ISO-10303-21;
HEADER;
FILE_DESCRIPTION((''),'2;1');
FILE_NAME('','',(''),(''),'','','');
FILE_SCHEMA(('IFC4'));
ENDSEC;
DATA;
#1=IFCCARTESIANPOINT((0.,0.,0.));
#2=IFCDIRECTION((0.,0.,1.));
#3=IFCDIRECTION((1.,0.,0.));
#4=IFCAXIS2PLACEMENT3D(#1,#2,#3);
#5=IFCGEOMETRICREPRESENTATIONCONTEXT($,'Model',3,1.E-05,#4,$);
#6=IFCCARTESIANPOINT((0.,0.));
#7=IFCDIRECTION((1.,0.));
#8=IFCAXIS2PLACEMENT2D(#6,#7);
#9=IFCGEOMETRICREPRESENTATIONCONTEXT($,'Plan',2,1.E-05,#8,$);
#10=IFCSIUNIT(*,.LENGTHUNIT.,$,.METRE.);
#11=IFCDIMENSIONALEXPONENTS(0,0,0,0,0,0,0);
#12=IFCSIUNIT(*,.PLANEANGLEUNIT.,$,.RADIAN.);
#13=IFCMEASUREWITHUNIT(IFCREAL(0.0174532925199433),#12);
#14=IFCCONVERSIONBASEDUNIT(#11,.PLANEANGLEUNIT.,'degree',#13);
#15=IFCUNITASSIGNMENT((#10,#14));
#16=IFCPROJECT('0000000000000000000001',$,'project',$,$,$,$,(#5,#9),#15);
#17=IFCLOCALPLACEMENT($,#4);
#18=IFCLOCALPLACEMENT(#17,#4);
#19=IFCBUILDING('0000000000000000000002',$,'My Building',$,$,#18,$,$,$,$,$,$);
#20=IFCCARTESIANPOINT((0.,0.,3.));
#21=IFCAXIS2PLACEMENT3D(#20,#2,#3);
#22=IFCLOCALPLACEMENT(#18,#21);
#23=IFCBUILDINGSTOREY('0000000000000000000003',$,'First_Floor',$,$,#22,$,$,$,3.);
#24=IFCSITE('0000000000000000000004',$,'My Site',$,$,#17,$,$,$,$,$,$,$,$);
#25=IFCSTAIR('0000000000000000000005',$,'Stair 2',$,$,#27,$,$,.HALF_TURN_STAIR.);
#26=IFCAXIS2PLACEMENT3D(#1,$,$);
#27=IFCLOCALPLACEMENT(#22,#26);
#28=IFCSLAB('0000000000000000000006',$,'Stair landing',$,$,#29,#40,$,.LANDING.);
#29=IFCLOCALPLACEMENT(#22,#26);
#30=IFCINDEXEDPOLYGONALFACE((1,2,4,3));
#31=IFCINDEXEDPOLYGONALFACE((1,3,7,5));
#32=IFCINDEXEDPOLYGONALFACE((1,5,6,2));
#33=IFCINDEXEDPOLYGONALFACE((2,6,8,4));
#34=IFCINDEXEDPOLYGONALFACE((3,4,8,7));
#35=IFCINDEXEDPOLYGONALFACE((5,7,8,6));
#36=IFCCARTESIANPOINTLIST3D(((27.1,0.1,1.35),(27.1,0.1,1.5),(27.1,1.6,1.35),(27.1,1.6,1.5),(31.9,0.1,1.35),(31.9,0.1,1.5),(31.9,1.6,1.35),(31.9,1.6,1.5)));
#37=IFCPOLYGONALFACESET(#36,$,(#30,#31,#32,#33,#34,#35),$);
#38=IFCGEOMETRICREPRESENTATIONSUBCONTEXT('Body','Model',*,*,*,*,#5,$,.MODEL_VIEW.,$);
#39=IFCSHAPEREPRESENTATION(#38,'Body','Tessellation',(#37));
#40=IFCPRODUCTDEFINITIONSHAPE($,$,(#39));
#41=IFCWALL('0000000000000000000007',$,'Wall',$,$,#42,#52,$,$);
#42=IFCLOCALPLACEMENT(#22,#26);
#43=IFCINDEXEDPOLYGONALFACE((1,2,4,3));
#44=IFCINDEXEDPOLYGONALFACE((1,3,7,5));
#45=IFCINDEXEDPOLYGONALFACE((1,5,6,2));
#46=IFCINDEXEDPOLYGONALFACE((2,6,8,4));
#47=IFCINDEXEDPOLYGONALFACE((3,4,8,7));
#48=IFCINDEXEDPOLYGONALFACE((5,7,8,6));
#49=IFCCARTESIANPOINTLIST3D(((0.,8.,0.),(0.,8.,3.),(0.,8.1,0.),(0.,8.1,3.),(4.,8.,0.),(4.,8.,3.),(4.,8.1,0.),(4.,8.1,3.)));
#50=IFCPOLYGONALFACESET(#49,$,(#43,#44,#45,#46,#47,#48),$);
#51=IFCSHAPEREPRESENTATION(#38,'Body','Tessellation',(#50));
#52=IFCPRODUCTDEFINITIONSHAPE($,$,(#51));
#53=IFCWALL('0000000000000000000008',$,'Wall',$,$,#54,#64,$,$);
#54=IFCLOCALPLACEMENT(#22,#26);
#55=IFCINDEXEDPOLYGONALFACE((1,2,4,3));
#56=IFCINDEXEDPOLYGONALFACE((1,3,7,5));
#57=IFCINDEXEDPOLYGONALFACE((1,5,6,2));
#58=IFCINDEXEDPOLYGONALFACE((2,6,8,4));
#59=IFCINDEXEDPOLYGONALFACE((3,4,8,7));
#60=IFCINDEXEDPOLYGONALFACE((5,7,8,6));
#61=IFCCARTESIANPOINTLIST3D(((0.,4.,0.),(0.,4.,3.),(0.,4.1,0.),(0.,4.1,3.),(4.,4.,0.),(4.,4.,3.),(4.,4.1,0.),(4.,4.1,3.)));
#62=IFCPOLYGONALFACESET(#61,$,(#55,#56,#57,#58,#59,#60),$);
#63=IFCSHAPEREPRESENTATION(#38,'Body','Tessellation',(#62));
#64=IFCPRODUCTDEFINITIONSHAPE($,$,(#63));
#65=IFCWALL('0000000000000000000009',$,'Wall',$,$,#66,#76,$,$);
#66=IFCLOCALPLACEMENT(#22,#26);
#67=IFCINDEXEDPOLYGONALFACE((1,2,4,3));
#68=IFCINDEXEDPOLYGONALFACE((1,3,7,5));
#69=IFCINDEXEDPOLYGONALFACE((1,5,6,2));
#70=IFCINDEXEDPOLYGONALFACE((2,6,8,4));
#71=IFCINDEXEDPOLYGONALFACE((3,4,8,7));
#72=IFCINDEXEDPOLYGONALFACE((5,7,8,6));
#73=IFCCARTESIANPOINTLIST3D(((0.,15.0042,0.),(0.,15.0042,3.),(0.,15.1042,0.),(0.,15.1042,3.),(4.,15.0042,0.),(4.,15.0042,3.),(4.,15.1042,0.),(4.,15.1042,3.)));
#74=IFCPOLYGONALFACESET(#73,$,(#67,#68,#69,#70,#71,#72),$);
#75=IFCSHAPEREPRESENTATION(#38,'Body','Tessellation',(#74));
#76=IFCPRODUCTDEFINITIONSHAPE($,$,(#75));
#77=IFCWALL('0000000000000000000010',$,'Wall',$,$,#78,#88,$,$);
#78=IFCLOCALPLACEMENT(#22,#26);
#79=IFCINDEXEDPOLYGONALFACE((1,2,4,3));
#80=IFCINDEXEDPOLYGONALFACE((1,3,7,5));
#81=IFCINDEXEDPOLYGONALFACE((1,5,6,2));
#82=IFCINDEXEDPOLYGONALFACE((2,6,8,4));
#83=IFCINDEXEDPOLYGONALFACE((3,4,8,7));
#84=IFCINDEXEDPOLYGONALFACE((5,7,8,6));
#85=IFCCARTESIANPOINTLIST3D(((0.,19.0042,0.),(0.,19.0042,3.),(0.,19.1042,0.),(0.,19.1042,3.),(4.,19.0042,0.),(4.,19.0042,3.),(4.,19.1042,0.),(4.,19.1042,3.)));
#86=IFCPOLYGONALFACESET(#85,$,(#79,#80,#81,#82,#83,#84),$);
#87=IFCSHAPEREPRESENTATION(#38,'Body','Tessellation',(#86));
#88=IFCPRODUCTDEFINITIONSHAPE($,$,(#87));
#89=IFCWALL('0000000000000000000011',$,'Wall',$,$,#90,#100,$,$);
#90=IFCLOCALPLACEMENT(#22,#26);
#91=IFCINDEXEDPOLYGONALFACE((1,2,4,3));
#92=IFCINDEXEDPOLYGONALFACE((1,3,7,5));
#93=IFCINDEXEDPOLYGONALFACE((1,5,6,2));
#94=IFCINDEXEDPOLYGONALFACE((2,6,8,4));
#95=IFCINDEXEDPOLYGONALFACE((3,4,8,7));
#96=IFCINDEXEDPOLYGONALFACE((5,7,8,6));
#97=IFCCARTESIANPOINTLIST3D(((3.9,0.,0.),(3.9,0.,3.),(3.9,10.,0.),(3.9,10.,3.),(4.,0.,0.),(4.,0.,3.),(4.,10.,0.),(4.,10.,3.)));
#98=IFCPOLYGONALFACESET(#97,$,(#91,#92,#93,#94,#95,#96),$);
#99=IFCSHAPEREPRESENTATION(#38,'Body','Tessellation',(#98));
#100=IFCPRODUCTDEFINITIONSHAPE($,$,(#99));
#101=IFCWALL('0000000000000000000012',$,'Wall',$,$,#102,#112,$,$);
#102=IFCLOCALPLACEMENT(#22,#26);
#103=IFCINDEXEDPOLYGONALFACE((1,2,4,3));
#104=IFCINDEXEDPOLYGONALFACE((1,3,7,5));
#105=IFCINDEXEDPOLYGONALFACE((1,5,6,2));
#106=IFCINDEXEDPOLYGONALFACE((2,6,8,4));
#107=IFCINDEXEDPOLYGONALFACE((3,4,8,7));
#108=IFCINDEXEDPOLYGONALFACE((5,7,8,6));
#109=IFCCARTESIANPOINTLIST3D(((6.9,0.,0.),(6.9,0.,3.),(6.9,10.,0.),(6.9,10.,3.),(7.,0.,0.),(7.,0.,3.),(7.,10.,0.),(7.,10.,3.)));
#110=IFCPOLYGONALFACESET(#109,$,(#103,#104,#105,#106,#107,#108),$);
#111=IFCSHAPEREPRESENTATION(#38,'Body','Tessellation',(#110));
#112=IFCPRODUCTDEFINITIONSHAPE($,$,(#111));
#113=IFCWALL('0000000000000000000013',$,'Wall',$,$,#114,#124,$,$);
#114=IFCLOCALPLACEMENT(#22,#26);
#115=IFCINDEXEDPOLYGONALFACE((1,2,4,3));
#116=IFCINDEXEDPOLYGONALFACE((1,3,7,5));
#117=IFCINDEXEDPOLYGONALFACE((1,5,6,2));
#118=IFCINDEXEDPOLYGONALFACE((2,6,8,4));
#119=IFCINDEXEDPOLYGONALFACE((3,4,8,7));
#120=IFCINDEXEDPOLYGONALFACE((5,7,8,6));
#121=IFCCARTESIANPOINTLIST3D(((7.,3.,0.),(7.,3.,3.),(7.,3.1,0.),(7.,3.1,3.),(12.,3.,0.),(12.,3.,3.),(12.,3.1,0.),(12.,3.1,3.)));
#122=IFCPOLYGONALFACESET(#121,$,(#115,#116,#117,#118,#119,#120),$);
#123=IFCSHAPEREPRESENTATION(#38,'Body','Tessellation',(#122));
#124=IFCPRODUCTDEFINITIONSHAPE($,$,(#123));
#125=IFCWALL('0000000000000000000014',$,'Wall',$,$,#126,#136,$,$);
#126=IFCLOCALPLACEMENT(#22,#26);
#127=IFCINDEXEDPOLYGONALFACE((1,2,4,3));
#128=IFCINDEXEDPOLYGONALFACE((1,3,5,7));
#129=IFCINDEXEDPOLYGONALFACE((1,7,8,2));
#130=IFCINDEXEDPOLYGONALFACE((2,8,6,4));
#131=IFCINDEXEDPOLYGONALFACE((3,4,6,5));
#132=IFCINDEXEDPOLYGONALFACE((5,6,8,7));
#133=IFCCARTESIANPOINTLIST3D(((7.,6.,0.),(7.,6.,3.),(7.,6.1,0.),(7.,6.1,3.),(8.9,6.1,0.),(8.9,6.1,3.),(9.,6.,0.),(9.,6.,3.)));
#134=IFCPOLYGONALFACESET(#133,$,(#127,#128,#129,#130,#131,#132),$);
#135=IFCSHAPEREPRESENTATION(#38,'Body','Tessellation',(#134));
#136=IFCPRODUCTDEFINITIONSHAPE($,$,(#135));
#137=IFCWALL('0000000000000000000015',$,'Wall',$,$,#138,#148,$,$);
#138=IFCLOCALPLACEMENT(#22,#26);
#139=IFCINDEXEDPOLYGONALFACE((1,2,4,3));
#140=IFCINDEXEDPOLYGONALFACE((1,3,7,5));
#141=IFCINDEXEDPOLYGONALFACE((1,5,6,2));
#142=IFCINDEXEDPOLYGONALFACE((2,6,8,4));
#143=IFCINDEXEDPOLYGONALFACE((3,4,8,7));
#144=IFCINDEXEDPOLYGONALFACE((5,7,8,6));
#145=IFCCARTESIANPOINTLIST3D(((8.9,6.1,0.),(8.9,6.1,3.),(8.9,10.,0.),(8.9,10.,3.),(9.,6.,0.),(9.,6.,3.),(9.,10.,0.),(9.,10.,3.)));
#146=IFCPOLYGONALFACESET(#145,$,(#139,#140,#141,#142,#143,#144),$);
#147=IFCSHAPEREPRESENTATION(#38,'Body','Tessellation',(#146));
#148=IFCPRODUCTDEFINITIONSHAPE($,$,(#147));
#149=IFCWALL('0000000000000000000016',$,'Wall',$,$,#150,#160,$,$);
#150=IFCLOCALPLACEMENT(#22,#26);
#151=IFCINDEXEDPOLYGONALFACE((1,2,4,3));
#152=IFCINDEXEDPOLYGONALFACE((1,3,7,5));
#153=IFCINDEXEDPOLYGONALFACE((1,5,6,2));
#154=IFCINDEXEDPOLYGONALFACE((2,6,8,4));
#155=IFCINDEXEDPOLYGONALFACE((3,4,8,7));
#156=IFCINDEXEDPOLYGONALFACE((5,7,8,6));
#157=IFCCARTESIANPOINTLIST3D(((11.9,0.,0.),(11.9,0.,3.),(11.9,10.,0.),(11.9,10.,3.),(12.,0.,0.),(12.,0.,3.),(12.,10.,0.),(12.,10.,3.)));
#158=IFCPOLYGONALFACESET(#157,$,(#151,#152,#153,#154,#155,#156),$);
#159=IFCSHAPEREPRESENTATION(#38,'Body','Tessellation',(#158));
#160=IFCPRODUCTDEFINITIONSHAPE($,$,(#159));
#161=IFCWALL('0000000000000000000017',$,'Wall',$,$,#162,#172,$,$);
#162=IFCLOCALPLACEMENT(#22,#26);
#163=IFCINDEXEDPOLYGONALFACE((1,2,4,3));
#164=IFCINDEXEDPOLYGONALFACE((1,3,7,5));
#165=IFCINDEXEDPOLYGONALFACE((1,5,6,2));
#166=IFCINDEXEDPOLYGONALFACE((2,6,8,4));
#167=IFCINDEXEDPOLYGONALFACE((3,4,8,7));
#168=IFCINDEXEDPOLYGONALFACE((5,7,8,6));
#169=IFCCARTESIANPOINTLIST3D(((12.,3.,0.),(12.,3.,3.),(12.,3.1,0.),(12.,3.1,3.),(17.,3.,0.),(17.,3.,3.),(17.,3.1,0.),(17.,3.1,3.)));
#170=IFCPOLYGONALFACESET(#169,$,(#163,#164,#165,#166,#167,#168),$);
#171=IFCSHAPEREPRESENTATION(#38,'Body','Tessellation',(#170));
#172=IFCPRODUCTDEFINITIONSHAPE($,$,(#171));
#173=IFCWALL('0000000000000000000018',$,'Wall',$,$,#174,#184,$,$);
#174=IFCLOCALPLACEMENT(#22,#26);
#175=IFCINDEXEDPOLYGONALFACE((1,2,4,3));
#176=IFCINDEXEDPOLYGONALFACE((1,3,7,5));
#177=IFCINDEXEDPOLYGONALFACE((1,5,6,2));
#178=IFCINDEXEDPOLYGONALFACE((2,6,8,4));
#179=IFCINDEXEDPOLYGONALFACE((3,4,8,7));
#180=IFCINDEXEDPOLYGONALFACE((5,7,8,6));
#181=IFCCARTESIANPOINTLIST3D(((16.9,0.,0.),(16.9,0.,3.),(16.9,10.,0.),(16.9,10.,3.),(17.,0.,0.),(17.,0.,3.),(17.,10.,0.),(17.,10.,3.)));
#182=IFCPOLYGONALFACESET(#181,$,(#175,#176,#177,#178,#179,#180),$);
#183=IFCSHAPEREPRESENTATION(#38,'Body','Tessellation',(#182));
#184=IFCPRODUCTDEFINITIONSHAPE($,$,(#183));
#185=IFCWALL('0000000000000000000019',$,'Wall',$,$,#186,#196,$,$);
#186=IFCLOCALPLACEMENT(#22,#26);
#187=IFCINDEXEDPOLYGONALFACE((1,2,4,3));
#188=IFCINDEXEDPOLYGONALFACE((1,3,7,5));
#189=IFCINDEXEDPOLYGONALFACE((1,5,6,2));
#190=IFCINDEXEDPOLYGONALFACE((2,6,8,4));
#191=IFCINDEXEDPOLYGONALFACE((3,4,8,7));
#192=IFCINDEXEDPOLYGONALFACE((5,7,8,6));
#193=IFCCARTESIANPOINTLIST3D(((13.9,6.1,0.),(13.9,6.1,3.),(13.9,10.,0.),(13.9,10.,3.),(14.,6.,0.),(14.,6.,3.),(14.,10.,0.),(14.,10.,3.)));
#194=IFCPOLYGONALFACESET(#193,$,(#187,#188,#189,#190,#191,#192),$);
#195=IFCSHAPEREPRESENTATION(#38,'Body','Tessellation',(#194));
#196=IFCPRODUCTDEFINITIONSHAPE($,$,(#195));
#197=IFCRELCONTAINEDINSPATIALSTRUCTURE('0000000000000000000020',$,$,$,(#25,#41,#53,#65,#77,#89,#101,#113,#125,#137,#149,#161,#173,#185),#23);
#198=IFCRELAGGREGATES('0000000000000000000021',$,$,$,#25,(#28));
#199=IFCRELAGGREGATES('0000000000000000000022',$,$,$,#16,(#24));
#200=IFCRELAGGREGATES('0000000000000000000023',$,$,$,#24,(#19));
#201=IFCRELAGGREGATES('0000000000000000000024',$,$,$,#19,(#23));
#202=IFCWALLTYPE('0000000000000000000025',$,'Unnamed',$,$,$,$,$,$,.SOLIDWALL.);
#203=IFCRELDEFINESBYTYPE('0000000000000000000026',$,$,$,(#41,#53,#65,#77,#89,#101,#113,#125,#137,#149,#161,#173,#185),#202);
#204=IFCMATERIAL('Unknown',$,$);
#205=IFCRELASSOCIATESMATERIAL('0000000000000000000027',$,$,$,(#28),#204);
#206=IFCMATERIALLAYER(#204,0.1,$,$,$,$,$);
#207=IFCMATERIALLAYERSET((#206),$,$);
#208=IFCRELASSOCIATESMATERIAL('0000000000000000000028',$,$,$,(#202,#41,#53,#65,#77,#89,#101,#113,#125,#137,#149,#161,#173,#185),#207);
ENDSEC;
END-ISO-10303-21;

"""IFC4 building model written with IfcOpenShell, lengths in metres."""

from ifc_helpers import new_model, entity, si_unit, converted_unit, frame, frame_2d, origin_with_axes, origin_2d_with_axis, place, context, subcontext, project, spatial, line, indexed_curve, rectangle, outline, extrude, material, layer, layer_set, layer_usage, type_object, element, aggregate, save


model = new_model("IFC4")

# Units and contexts
model_context = context("Model", 3, precision=1e-05, world=origin_with_axes())
plan_context = context("Plan", 2, precision=1e-05, world=origin_2d_with_axis())
body_context = subcontext(model_context, "Body", "Model", "MODEL_VIEW")
ifc_project = project(units=[si_unit("LENGTHUNIT", "METRE"), converted_unit("PLANEANGLEUNIT", "degree", entity("IfcReal", 0.0174532925199433), si_unit("PLANEANGLEUNIT", "RADIAN"), dimensions=[0, 0, 0, 0, 0, 0, 0])], contexts=[model_context, plan_context])

# Site, building, storey
site_placement = place(None, origin_with_axes())
site = spatial("IfcSite", under=ifc_project, at=site_placement, Name="My Site")
building_placement = place(site_placement, origin_with_axes())
building = spatial("IfcBuilding", under=site, at=building_placement, Name="My Building")
storey_placement = place(building_placement, frame((0.0, 0.0, 3.0), z_axis=(0.0, 0.0, 1.0), x_axis=(1.0, 0.0, 0.0)))
storey = spatial("IfcBuildingStorey", under=building, at=storey_placement, Name="First_Floor", Elevation=3.0)

# Stair, slab
stair_placement = place(storey_placement, origin_with_axes())
stair = element("IfcStair", 1, at=stair_placement, inside=storey, Name="Stair 2", PredefinedType="HALF_TURN_STAIR")
ifc_material = material(Name="Unknown")
slab_placement = place(stair_placement, origin_with_axes())
slab = element("IfcSlab", 2, at=slab_placement, material=ifc_material, Name="Stair landing", PredefinedType="LANDING", context=body_context, shape_type="SweptSolid", body=[
    extrude(rectangle(XDim=4.8, YDim=1.5, at=frame_2d((29.5, 0.85))), frame((0.0, 0.0, 1.35)), (0.0, 0.0, 1.0), 0.15),
])

# Walls
ifc_layer = layer(ifc_material, 0.1)
ifc_layer_set = layer_set([ifc_layer])
ifc_layer_usage_1 = layer_usage(ifc_layer_set, "AXIS2", "POSITIVE", 0.0)
wall_type = type_object("IfcWallType", Name="Unnamed", PredefinedType="SOLIDWALL", material=ifc_layer_set)
wall_1_placement = place(storey_placement, frame((0.0, 8.0, 0.0), z_axis=(0.0, 0.0, 1.0), x_axis=(1.0, 0.0, 0.0)))
element("IfcWall", 3, at=wall_1_placement, inside=storey, type_object=wall_type, material=ifc_layer_usage_1, Name="Wall", context=body_context, shape_type="SweptSolid", body=[
    extrude(outline(indexed_curve([(0.0, 0.0), (0.0, 0.1), (4.0, 0.1), (4.0, 0.0)], segments=[line(1, 2, 3, 4, 1)])), origin_with_axes(), (0.0, 0.0, 1.0), 3.0),
])
ifc_layer_usage_2 = layer_usage(ifc_layer_set, "AXIS2", "POSITIVE", 0.0)
wall_2_placement = place(storey_placement, frame((0.0, 4.0, 0.0), z_axis=(0.0, 0.0, 1.0), x_axis=(1.0, 0.0, 0.0)))
element("IfcWall", 4, at=wall_2_placement, inside=storey, type_object=wall_type, material=ifc_layer_usage_2, Name="Wall", context=body_context, shape_type="SweptSolid", body=[
    extrude(outline(indexed_curve([(0.0, 0.0), (0.0, 0.1), (4.0, 0.1), (4.0, 0.0)], segments=[line(1, 2, 3, 4, 1)])), origin_with_axes(), (0.0, 0.0, 1.0), 3.0),
])
ifc_layer_usage_3 = layer_usage(ifc_layer_set, "AXIS2", "POSITIVE", 0.0)
wall_3_placement = place(storey_placement, frame((0.0, 15.0042, 0.0), z_axis=(0.0, 0.0, 1.0), x_axis=(1.0, 0.0, 0.0)))
element("IfcWall", 5, at=wall_3_placement, inside=storey, type_object=wall_type, material=ifc_layer_usage_3, Name="Wall", context=body_context, shape_type="SweptSolid", body=[
    extrude(outline(indexed_curve([(0.0, 0.0), (0.0, 0.1), (4.0, 0.1), (4.0, 0.0)], segments=[line(1, 2, 3, 4, 1)])), origin_with_axes(), (0.0, 0.0, 1.0), 3.0),
])
ifc_layer_usage_4 = layer_usage(ifc_layer_set, "AXIS2", "POSITIVE", 0.0)
wall_4_placement = place(storey_placement, frame((0.0, 19.0042, 0.0), z_axis=(0.0, 0.0, 1.0), x_axis=(1.0, 0.0, 0.0)))
element("IfcWall", 6, at=wall_4_placement, inside=storey, type_object=wall_type, material=ifc_layer_usage_4, Name="Wall", context=body_context, shape_type="SweptSolid", body=[
    extrude(outline(indexed_curve([(0.0, 0.0), (0.0, 0.1), (4.0, 0.1), (4.0, 0.0)], segments=[line(1, 2, 3, 4, 1)])), origin_with_axes(), (0.0, 0.0, 1.0), 3.0),
])
ifc_layer_usage_5 = layer_usage(ifc_layer_set, "AXIS2", "POSITIVE", 0.0)
wall_5_placement = place(storey_placement, frame((3.9, 10.0, 0.0), z_axis=(0.0, 0.0, 1.0), x_axis=(0.0, -1.0, 0.0)))
element("IfcWall", 7, at=wall_5_placement, inside=storey, type_object=wall_type, material=ifc_layer_usage_5, Name="Wall", context=body_context, shape_type="SweptSolid", body=[
    extrude(outline(indexed_curve([(0.0, 0.0), (0.0, 0.1), (10.0, 0.1), (10.0, 0.0)], segments=[line(1, 2, 3, 4, 1)])), origin_with_axes(), (0.0, 0.0, 1.0), 3.0),
])
ifc_layer_usage_6 = layer_usage(ifc_layer_set, "AXIS2", "POSITIVE", 0.0)
wall_6_placement = place(storey_placement, frame((6.9, 10.0, 0.0), z_axis=(0.0, 0.0, 1.0), x_axis=(0.0, -1.0, 0.0)))
element("IfcWall", 8, at=wall_6_placement, inside=storey, type_object=wall_type, material=ifc_layer_usage_6, Name="Wall", context=body_context, shape_type="SweptSolid", body=[
    extrude(outline(indexed_curve([(0.0, 0.0), (0.0, 0.1), (10.0, 0.1), (10.0, 0.0)], segments=[line(1, 2, 3, 4, 1)])), origin_with_axes(), (0.0, 0.0, 1.0), 3.0),
])
ifc_layer_usage_7 = layer_usage(ifc_layer_set, "AXIS2", "POSITIVE", 0.0)
wall_7_placement = place(storey_placement, frame((7.0, 3.0, 0.0), z_axis=(0.0, 0.0, 1.0), x_axis=(1.0, 0.0, 0.0)))
element("IfcWall", 9, at=wall_7_placement, inside=storey, type_object=wall_type, material=ifc_layer_usage_7, Name="Wall", context=body_context, shape_type="SweptSolid", body=[
    extrude(outline(indexed_curve([(0.0, 0.0), (0.0, 0.1), (5.0, 0.1), (5.0, 0.0)], segments=[line(1, 2, 3, 4, 1)])), origin_with_axes(), (0.0, 0.0, 1.0), 3.0),
])
ifc_layer_usage_8 = layer_usage(ifc_layer_set, "AXIS2", "POSITIVE", 0.0)
wall_8_placement = place(storey_placement, frame((7.0, 6.0, 0.0), z_axis=(0.0, 0.0, 1.0), x_axis=(1.0, 0.0, 0.0)))
element("IfcWall", 10, at=wall_8_placement, inside=storey, type_object=wall_type, material=ifc_layer_usage_8, Name="Wall", context=body_context, shape_type="SweptSolid", body=[
    extrude(outline(indexed_curve([(0.0, 0.0), (0.0, 0.1), (1.9, 0.1), (2.0, 0.0)], segments=[line(1, 2, 3, 4, 1)])), origin_with_axes(), (0.0, 0.0, 1.0), 3.0),
])
ifc_layer_usage_9 = layer_usage(ifc_layer_set, "AXIS2", "POSITIVE", 0.0)
wall_9_placement = place(storey_placement, frame((9.0, 6.0, 0.0), z_axis=(0.0, 0.0, 1.0), x_axis=(0.0, 1.0, 0.0)))
element("IfcWall", 11, at=wall_9_placement, inside=storey, type_object=wall_type, material=ifc_layer_usage_9, Name="Wall", context=body_context, shape_type="SweptSolid", body=[
    extrude(outline(indexed_curve([(0.0, 0.0), (0.1, 0.1), (4.0, 0.1), (4.0, 0.0)], segments=[line(1, 2, 3, 4, 1)])), origin_with_axes(), (0.0, 0.0, 1.0), 3.0),
])
ifc_layer_usage_10 = layer_usage(ifc_layer_set, "AXIS2", "POSITIVE", 0.0)
wall_10_placement = place(storey_placement, frame((11.9, 10.0, 0.0), z_axis=(0.0, 0.0, 1.0), x_axis=(0.0, -1.0, 0.0)))
element("IfcWall", 12, at=wall_10_placement, inside=storey, type_object=wall_type, material=ifc_layer_usage_10, Name="Wall", context=body_context, shape_type="SweptSolid", body=[
    extrude(outline(indexed_curve([(0.0, 0.0), (0.0, 0.1), (10.0, 0.1), (10.0, 0.0)], segments=[line(1, 2, 3, 4, 1)])), origin_with_axes(), (0.0, 0.0, 1.0), 3.0),
])
ifc_layer_usage_11 = layer_usage(ifc_layer_set, "AXIS2", "POSITIVE", 0.0)
wall_11_placement = place(storey_placement, frame((12.0, 3.0, 0.0), z_axis=(0.0, 0.0, 1.0), x_axis=(1.0, 0.0, 0.0)))
element("IfcWall", 13, at=wall_11_placement, inside=storey, type_object=wall_type, material=ifc_layer_usage_11, Name="Wall", context=body_context, shape_type="SweptSolid", body=[
    extrude(outline(indexed_curve([(0.0, 0.0), (0.0, 0.1), (5.0, 0.1), (5.0, 0.0)], segments=[line(1, 2, 3, 4, 1)])), origin_with_axes(), (0.0, 0.0, 1.0), 3.0),
])
ifc_layer_usage_12 = layer_usage(ifc_layer_set, "AXIS2", "POSITIVE", 0.0)
wall_12_placement = place(storey_placement, frame((16.9, 10.0, 0.0), z_axis=(0.0, 0.0, 1.0), x_axis=(0.0, -1.0, 0.0)))
element("IfcWall", 14, at=wall_12_placement, inside=storey, type_object=wall_type, material=ifc_layer_usage_12, Name="Wall", context=body_context, shape_type="SweptSolid", body=[
    extrude(outline(indexed_curve([(0.0, 0.0), (0.0, 0.1), (10.0, 0.1), (10.0, 0.0)], segments=[line(1, 2, 3, 4, 1)])), origin_with_axes(), (0.0, 0.0, 1.0), 3.0),
])
ifc_layer_usage_13 = layer_usage(ifc_layer_set, "AXIS2", "POSITIVE", 0.0)
wall_13_placement = place(storey_placement, frame((14.0, 6.0, 0.0), z_axis=(0.0, 0.0, 1.0), x_axis=(0.0, 1.0, 0.0)))
element("IfcWall", 15, at=wall_13_placement, inside=storey, type_object=wall_type, material=ifc_layer_usage_13, Name="Wall", context=body_context, shape_type="SweptSolid", body=[
    extrude(outline(indexed_curve([(0.0, 0.0), (0.1, 0.1), (4.0, 0.1), (4.0, 0.0)], segments=[line(1, 2, 3, 4, 1)])), origin_with_axes(), (0.0, 0.0, 1.0), 3.0),
])

aggregate(stair, [slab])

save(model, "model.ifc")
